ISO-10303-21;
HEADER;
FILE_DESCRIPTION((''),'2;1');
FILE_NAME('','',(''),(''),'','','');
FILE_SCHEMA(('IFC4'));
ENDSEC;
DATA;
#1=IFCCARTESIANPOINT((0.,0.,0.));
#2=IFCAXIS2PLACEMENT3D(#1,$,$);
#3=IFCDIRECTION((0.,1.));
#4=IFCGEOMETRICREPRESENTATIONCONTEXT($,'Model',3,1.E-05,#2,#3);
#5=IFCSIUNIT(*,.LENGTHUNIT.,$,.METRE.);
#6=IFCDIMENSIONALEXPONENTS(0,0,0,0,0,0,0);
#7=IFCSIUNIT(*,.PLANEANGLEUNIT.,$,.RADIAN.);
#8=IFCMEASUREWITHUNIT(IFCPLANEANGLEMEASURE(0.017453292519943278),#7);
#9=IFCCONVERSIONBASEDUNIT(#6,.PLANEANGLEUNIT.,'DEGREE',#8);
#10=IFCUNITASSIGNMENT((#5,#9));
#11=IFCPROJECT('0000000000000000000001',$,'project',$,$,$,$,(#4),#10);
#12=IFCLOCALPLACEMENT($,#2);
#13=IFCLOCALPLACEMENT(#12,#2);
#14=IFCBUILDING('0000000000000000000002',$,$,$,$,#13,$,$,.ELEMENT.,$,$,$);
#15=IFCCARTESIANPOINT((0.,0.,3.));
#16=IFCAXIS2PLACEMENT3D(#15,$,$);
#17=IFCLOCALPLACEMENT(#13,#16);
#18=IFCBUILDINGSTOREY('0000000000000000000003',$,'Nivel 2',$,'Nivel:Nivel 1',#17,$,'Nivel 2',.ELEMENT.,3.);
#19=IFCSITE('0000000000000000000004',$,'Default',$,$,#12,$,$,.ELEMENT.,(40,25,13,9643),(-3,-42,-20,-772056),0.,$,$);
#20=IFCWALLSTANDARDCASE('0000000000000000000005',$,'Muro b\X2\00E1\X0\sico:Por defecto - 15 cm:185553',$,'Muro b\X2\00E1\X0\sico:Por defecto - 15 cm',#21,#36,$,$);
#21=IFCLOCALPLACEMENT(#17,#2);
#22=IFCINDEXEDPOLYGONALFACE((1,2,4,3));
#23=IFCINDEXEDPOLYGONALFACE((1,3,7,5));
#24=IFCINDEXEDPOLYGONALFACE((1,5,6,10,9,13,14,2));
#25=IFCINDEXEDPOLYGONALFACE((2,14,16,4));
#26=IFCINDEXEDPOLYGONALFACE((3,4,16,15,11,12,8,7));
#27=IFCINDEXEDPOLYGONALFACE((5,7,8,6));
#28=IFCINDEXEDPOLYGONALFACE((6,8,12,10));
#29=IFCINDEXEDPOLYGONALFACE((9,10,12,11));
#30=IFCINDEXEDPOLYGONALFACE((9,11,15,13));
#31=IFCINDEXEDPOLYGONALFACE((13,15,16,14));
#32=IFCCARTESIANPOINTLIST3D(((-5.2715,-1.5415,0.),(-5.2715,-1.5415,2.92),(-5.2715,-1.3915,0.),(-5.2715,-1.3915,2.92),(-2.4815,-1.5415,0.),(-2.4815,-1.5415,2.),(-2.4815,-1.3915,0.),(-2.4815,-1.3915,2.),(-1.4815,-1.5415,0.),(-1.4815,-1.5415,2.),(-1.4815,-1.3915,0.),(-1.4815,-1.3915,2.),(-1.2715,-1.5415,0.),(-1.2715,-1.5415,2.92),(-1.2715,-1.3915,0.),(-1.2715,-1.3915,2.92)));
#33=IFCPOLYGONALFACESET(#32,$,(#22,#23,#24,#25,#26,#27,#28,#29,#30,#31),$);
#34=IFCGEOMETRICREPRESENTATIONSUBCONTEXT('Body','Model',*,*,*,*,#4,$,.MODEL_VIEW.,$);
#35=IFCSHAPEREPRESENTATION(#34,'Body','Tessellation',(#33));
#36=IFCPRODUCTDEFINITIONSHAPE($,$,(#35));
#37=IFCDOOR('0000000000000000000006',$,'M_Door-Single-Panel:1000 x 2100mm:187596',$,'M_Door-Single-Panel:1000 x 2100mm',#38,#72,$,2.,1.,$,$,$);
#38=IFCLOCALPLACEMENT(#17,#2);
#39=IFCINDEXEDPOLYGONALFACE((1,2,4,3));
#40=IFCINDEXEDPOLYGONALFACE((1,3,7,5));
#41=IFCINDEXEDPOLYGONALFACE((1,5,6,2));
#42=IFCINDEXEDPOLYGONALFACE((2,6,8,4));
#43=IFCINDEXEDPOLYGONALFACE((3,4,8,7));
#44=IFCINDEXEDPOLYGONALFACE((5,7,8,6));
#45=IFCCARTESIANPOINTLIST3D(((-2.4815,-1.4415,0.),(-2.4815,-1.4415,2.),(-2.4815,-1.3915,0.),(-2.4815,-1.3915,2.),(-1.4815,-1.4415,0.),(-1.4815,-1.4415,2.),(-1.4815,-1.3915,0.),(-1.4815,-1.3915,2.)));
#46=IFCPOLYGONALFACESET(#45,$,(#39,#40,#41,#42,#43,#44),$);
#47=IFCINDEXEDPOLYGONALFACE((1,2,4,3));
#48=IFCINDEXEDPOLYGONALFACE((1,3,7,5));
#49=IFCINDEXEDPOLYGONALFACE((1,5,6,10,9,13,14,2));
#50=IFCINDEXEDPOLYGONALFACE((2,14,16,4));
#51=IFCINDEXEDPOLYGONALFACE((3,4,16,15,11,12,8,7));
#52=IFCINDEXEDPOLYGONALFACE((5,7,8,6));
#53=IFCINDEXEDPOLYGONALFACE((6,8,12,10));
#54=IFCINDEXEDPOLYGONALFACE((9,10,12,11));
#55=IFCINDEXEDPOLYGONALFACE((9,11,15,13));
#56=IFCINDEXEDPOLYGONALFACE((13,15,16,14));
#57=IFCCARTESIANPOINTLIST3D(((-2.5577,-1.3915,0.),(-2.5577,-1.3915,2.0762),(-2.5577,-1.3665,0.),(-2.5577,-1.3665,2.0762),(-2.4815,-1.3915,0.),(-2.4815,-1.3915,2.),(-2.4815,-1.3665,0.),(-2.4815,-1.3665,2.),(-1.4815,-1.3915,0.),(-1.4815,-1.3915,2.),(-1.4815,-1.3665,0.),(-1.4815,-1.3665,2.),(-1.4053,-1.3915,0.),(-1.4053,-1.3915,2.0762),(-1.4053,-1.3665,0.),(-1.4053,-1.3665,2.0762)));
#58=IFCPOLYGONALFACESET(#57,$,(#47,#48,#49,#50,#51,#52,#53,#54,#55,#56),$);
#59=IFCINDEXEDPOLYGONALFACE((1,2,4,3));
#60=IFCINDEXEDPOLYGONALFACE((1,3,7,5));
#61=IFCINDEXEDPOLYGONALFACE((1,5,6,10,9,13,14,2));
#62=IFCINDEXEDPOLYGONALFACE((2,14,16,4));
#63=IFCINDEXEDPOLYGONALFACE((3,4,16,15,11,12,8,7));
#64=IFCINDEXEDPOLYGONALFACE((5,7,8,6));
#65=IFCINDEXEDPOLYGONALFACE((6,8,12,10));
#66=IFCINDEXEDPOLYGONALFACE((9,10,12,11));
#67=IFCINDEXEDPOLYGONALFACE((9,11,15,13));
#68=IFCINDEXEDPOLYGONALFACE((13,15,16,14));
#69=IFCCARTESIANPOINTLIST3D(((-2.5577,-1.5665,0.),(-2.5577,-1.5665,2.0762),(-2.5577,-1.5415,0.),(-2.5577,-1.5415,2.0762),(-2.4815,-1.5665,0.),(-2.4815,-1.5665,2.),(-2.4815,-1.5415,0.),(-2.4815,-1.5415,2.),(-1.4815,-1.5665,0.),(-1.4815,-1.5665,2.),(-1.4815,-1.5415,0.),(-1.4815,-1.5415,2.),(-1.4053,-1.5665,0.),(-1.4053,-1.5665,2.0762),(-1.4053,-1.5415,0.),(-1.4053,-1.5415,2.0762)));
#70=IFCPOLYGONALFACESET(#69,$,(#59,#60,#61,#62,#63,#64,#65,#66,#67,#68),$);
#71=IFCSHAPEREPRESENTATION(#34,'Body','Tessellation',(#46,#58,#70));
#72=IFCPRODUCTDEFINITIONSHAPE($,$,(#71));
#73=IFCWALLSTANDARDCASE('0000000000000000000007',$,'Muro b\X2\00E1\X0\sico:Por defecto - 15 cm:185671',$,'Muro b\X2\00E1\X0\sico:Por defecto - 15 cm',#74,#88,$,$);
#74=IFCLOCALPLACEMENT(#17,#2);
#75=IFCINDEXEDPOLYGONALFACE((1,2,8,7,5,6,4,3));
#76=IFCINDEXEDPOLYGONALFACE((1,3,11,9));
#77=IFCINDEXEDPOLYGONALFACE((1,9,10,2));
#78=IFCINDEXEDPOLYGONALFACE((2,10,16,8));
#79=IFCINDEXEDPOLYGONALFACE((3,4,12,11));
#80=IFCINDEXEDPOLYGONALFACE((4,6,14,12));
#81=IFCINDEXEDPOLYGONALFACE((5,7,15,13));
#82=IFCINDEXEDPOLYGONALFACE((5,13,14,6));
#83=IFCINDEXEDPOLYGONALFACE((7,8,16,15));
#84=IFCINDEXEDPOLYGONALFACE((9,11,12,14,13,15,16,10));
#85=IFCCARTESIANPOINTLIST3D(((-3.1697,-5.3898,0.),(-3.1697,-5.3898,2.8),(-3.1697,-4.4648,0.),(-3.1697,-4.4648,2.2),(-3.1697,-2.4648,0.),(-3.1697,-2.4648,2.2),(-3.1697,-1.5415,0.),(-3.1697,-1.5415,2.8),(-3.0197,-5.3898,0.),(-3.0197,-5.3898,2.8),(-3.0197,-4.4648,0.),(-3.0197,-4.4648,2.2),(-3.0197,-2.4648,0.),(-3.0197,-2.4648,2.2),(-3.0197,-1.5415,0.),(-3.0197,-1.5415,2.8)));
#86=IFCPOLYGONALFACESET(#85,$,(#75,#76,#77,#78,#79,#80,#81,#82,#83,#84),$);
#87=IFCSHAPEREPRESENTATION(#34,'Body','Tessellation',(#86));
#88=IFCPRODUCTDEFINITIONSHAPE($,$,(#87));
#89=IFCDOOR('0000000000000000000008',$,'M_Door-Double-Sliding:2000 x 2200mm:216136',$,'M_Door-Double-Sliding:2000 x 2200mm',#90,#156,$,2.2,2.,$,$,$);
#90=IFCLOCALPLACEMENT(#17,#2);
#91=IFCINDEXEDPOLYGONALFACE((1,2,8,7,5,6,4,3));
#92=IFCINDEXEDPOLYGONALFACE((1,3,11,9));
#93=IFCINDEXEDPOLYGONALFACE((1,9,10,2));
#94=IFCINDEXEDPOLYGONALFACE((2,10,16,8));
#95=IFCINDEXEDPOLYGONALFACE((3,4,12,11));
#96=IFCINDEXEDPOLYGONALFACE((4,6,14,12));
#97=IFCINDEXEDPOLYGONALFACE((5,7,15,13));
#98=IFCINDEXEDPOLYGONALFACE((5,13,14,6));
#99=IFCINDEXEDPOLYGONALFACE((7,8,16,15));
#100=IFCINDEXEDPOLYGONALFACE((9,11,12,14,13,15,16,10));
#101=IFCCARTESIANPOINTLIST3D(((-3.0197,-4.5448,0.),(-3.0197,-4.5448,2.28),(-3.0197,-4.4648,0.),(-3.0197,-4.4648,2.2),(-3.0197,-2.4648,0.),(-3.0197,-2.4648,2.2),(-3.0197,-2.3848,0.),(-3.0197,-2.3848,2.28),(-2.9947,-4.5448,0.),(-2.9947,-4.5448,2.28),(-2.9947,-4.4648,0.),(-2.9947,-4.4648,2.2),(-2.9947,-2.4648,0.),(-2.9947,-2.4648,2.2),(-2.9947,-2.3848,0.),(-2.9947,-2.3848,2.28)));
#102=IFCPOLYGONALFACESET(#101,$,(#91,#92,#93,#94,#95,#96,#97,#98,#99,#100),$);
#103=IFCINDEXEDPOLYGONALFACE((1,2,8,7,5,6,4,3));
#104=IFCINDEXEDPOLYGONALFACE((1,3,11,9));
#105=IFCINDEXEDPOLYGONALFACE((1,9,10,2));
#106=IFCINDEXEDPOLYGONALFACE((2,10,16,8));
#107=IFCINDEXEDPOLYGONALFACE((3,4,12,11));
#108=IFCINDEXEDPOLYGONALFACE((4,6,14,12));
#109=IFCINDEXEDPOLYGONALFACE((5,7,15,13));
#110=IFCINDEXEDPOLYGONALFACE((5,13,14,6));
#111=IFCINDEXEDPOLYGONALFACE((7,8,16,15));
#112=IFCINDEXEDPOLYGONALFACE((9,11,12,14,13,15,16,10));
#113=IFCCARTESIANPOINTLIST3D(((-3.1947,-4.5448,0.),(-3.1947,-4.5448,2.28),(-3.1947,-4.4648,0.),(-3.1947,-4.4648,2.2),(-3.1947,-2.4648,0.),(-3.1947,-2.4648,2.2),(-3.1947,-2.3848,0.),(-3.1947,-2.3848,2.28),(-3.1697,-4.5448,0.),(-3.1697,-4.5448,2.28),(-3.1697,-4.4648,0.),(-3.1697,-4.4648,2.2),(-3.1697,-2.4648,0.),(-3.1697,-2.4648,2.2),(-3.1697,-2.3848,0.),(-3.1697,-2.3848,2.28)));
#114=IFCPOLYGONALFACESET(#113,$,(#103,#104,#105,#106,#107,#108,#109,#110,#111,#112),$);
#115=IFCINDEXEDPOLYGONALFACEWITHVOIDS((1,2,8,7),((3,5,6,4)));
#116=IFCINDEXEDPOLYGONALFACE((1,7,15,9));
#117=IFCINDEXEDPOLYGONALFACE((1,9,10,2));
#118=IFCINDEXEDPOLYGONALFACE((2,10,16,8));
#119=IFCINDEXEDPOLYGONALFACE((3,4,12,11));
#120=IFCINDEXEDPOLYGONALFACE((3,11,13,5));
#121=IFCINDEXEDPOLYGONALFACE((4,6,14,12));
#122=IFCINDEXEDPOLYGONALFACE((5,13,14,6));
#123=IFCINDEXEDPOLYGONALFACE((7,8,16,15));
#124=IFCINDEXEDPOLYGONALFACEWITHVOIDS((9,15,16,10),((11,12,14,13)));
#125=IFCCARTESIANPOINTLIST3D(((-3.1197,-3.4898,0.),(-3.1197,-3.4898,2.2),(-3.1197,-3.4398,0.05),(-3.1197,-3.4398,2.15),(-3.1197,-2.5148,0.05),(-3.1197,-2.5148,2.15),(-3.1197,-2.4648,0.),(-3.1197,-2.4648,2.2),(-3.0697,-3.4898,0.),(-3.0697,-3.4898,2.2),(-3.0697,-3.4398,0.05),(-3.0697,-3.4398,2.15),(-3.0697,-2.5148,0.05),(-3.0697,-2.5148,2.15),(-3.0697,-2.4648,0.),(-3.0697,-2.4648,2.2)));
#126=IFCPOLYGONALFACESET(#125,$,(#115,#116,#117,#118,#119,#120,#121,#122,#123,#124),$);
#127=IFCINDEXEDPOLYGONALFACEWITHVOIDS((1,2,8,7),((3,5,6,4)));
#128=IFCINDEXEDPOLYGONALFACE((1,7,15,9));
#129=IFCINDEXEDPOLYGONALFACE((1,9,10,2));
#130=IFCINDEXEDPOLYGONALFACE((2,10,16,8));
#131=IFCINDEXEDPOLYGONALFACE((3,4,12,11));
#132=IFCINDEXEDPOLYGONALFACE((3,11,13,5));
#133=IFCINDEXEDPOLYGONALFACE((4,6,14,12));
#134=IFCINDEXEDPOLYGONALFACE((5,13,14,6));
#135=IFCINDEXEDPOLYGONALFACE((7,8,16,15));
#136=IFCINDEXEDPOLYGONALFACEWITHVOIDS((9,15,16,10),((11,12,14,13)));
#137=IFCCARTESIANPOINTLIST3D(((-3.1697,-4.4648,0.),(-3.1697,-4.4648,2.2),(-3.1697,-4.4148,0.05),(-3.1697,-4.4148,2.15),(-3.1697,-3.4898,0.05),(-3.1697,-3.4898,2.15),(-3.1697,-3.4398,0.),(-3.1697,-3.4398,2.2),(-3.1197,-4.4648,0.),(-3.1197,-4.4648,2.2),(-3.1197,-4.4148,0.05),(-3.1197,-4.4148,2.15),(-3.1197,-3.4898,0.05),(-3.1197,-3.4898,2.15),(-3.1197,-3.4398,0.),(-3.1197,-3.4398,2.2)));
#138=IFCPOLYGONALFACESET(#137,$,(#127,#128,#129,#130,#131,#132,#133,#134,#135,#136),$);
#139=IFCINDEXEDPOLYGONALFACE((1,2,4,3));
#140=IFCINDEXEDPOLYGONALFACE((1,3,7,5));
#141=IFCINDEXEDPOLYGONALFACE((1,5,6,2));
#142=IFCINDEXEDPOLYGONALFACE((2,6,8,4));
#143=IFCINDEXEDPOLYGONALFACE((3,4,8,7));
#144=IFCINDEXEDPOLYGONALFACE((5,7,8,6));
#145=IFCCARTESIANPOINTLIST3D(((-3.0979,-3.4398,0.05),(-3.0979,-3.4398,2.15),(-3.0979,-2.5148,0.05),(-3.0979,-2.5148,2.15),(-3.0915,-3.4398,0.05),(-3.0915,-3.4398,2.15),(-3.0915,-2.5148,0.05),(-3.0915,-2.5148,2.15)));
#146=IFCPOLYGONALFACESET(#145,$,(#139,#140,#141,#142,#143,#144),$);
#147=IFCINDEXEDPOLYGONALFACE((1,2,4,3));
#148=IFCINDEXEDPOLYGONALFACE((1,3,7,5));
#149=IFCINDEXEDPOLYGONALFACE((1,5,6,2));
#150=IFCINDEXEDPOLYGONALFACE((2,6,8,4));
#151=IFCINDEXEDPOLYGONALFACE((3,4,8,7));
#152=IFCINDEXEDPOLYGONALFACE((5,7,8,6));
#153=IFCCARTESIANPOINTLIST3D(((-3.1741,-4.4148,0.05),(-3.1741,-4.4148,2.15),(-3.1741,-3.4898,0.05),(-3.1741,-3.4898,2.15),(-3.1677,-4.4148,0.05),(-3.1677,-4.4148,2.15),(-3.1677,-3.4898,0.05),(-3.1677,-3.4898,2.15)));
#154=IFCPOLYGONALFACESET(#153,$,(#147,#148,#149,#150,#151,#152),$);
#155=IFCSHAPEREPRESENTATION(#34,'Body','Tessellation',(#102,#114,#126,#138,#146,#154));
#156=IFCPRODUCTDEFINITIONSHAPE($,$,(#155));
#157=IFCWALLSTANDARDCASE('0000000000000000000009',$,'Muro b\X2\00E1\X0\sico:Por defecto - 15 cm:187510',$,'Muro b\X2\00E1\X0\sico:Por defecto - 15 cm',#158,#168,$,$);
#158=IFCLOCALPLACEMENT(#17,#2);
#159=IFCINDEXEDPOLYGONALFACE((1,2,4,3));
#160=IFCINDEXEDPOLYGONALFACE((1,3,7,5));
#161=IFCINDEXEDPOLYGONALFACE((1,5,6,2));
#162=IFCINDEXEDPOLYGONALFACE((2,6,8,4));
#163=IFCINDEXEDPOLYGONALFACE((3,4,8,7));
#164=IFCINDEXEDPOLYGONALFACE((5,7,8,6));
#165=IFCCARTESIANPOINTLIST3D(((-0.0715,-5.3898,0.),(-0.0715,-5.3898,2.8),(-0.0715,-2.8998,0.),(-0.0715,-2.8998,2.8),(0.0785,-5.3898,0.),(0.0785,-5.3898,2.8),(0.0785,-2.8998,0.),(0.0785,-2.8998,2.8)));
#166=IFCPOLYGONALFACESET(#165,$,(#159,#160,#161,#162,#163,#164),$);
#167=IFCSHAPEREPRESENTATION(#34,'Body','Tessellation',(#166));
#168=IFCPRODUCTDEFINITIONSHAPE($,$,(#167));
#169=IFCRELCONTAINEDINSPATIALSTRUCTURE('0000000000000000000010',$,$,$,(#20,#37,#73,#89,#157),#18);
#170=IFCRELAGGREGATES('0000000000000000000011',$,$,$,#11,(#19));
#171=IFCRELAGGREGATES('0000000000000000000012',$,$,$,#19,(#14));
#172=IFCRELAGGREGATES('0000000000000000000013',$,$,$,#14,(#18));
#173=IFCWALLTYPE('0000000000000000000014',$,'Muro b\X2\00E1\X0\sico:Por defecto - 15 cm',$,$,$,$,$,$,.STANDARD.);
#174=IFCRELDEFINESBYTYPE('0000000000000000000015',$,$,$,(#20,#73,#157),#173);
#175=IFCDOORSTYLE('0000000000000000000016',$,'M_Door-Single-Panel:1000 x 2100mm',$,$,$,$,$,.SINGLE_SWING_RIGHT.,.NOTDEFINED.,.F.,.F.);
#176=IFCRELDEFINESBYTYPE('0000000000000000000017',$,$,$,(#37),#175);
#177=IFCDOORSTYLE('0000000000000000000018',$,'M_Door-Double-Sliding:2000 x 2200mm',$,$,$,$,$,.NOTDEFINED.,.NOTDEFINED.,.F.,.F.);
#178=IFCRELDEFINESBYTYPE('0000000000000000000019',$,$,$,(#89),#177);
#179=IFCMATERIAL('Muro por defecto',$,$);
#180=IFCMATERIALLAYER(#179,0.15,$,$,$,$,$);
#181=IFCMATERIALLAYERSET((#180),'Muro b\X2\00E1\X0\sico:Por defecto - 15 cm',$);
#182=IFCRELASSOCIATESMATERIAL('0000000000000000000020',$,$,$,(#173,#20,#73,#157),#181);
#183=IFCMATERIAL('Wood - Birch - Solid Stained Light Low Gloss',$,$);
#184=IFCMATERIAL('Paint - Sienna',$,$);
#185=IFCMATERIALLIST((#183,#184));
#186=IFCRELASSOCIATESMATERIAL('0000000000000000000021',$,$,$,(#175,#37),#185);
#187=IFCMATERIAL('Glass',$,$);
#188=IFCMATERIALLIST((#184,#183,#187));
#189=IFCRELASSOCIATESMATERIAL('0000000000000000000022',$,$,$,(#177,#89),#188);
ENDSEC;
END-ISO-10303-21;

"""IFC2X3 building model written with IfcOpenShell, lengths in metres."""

from ifc_helpers import new_model, entity, si_unit, converted_unit, direction, frame, frame_2d, origin, origin_2d_with_axis, place, context, subcontext, project, spatial, polyline, rectangle, outline, extrude, clip, bounded_halfspace, source, transform, mapped, material, material_list, layer, layer_set, layer_usage, type_object, type_shapes, element, fill, save


model = new_model("IFC2X3")

# Units and contexts
model_context = context("Model", 3, precision=1e-05, world=origin(), true_north=direction((0.0, 1.0)))
body_context = subcontext(model_context, "Body", "Model", "MODEL_VIEW")
ifc_project = project(units=[si_unit("LENGTHUNIT", "METRE"), converted_unit("PLANEANGLEUNIT", "DEGREE", entity("IfcPlaneAngleMeasure", 0.017453292519943278), si_unit("PLANEANGLEUNIT", "RADIAN"), dimensions=[0, 0, 0, 0, 0, 0, 0])], contexts=[model_context])

# Site, building, storey
site_placement = place(None, origin())
site = spatial("IfcSite", under=ifc_project, at=site_placement, Name="Default", CompositionType="ELEMENT", RefLatitude=(40, 25, 13, 9643), RefLongitude=(-3, -42, -20, -772056), RefElevation=0.0)
building_placement = place(site_placement, origin())
building = spatial("IfcBuilding", under=site, at=building_placement, CompositionType="ELEMENT")
storey_placement = place(building_placement, frame((0.0, 0.0, 3.0)))
storey = spatial("IfcBuildingStorey", under=building, at=storey_placement, Name="Nivel 2", ObjectType="Nivel:Nivel 1", LongName="Nivel 2", CompositionType="ELEMENT", Elevation=3.0)

# Shared definitions
ifc_material_1 = material(Name="Muro por defecto")
ifc_layer_1 = layer(ifc_material_1, 0.15)
ifc_layer_set_1 = layer_set([ifc_layer_1], Name="Muro básico:Por defecto - 15 cm")
wall_type = type_object("IfcWallType", Name="Muro básico:Por defecto - 15 cm", PredefinedType="STANDARD", material=ifc_layer_set_1)

# Walls, openings, doors
ifc_material_2 = material(Name="Wood - Birch - Solid Stained Light Low Gloss")
ifc_material_3 = material(Name="Paint - Sienna")
ifc_material_list_1 = material_list([ifc_material_2, ifc_material_3])
ifc_layer_usage_1 = layer_usage(ifc_layer_set_1, "AXIS2", "NEGATIVE", 0.075)
wall_1_placement = place(storey_placement, frame((-1.2715, -1.4665, 0.0), z_axis=(0.0, 0.0, 1.0), x_axis=(-1.0, 0.0, 0.0)))
wall_1 = element("IfcWallStandardCase", 1, at=wall_1_placement, inside=storey, type_object=wall_type, material=ifc_layer_usage_1, Name="Muro básico:Por defecto - 15 cm:185553", ObjectType="Muro básico:Por defecto - 15 cm", context=body_context, shape_type="SweptSolid", body=[
    extrude(rectangle(XDim=4.0, YDim=0.15, at=frame_2d((2.0, 0.0), x_axis=(-1.0, 0.0))), origin(), (0.0, 0.0, 1.0), 2.92),
])
opening_1_placement = place(wall_1_placement, frame((1.21, 0.075, 0.0)))
opening_1 = element("IfcOpeningElement", 2, at=opening_1_placement, cuts=wall_1, ObjectType="Opening", context=body_context, shape_type="SweptSolid", body=[
    extrude(rectangle(XDim=1.0, YDim=2.0, at=frame_2d((1.0, 0.5), x_axis=(0.0, 1.0))), frame((0.0, 0.0, 0.0), z_axis=(0.0, -1.0, 0.0), x_axis=(0.0, 0.0, 1.0)), (0.0, 0.0, 1.0), 0.15),
])
door_style_1 = type_object("IfcDoorStyle", Name="M_Door-Single-Panel:1000 x 2100mm", ConstructionType="NOTDEFINED", OperationType="SINGLE_SWING_RIGHT", ParameterTakesPrecedence=False, Sizeable=False, material=ifc_material_list_1)
shared_shape_1 = source(origin(), body_context, "Body", "SweptSolid", [
    extrude(rectangle(XDim=0.05, YDim=1.0, at=origin_2d_with_axis()), frame((0.5, 0.125, 0.0), z_axis=(0.0, 0.0, 1.0), x_axis=(0.0, 1.0, 0.0)), (0.0, 0.0, 1.0), 2.0),
    extrude(outline(polyline([(-0.5762, -1.0571), (0.5762, -1.0571), (0.5762, 1.0191), (0.5, 1.0191), (0.5, -0.981), (-0.5, -0.981), (-0.5, 1.0191), (-0.5762, 1.0191), (-0.5762, -1.0571)])), frame((0.5, 0.15, 1.0191), z_axis=(0.0, 1.0, 0.0), x_axis=(1.0, 0.0, 0.0)), (0.0, 0.0, 1.0), 0.025),
    extrude(outline(polyline([(-1.0571, -0.5762), (1.019, -0.5762), (1.019, -0.5), (-0.9809, -0.5), (-0.9809, 0.5), (1.019, 0.5), (1.019, 0.5762), (-1.0571, 0.5762), (-1.0571, -0.5762)])), frame((0.5, -0.025, 1.019), z_axis=(0.0, 1.0, 0.0), x_axis=(0.0, 0.0, -1.0)), (0.0, 0.0, 1.0), 0.025),
])
type_shapes(door_style_1, [shared_shape_1])
door_1_placement = place(opening_1_placement, frame((0.0, 0.0, 0.0), z_axis=(0.0, 0.0, 1.0), x_axis=(-1.0, 0.0, 0.0)))
door_1 = element("IfcDoor", 3, at=door_1_placement, inside=storey, type_object=door_style_1, material=ifc_material_list_1, Name="M_Door-Single-Panel:1000 x 2100mm:187596", ObjectType="M_Door-Single-Panel:1000 x 2100mm", OverallHeight=2.0, OverallWidth=1.0, context=body_context, shape_type="MappedRepresentation", body=[
    mapped(shared_shape_1, transform((0.0, 0.0, 0.0), scale=1.0)),
])
fill(opening_1, door_1)
ifc_layer_usage_2 = layer_usage(ifc_layer_set_1, "AXIS2", "POSITIVE", -0.075)
wall_2_placement = place(storey_placement, frame((-3.0947, -1.5415, 0.0), z_axis=(0.0, 0.0, 1.0), x_axis=(0.0, -1.0, 0.0)))
wall_2 = element("IfcWallStandardCase", 4, at=wall_2_placement, inside=storey, type_object=wall_type, material=ifc_layer_usage_2, Name="Muro básico:Por defecto - 15 cm:185671", ObjectType="Muro básico:Por defecto - 15 cm", context=body_context, shape_type="Clipping", body=[
    clip(extrude(rectangle(XDim=3.8482, YDim=0.15, at=frame_2d((1.9241, 0.0), x_axis=(1.0, 0.0))), origin(), (0.0, 0.0, 1.0), 2.8), bounded_halfspace(frame((0.0, -0.075, 2.8), z_axis=(0.0, 0.0, -1.0), x_axis=(0.0, 1.0, 0.0)), True, frame((0.0, -0.075, 2.8)), polyline([(0.0, 0.0), (3.8482, 0.0), (3.8482, 0.15), (0.0, 0.15), (0.0, 0.0)]))),
])
opening_2_placement = place(wall_2_placement, frame((2.9232, 0.075, 0.0)))
opening_2 = element("IfcOpeningElement", 5, at=opening_2_placement, cuts=wall_2, ObjectType="Opening", context=body_context, shape_type="SweptSolid", body=[
    extrude(rectangle(XDim=2.2, YDim=2.0, at=frame_2d((1.1, 1.0), x_axis=(-1.0, 0.0))), frame((0.0, 0.0, 0.0), z_axis=(0.0, -1.0, 0.0), x_axis=(0.0, 0.0, 1.0)), (0.0, 0.0, 1.0), 0.15),
])
ifc_material_4 = material(Name="Glass")
ifc_material_list_2 = material_list([ifc_material_3, ifc_material_2, ifc_material_4])
door_style_2 = type_object("IfcDoorStyle", Name="M_Door-Double-Sliding:2000 x 2200mm", ConstructionType="NOTDEFINED", OperationType="NOTDEFINED", ParameterTakesPrecedence=False, Sizeable=False, material=ifc_material_list_2)
shared_shape_2 = source(origin(), body_context, "Body", "SweptSolid", [
    extrude(outline(polyline([(-1.12, -1.08), (1.16, -1.08), (1.16, 1.08), (-1.12, 1.08), (-1.12, 1.0), (1.08, 1.0), (1.08, -1.0), (-1.12, -1.0), (-1.12, -1.08)])), frame((1.0, -0.025, 1.12), z_axis=(0.0, 1.0, 0.0), x_axis=(0.0, 0.0, 1.0)), (0.0, 0.0, 1.0), 0.025),
    extrude(outline(polyline([(-1.08, -1.12), (-1.0, -1.12), (-1.0, 1.08), (1.0, 1.08), (1.0, -1.12), (1.08, -1.12), (1.08, 1.16), (-1.08, 1.16), (-1.08, -1.12)])), frame((1.0, 0.15, 1.12), z_axis=(0.0, 1.0, 0.0), x_axis=(-1.0, 0.0, 0.0)), (0.0, 0.0, 1.0), 0.025),
    extrude(outline(polyline([(-0.5125, -1.1), (0.5125, -1.1), (0.5125, 1.1), (-0.5125, 1.1), (-0.5125, -1.1)]), holes=[polyline([(-0.4625, -1.05), (-0.4625, 1.05), (0.4625, 1.05), (0.4625, -1.05), (-0.4625, -1.05)])]), frame((1.4875, 0.05, 1.1), z_axis=(0.0, 1.0, 0.0), x_axis=(1.0, 0.0, 0.0)), (0.0, 0.0, 1.0), 0.05),
    extrude(outline(polyline([(-1.1, -0.5125), (1.1, -0.5125), (1.1, 0.5125), (-1.1, 0.5125), (-1.1, -0.5125)]), holes=[polyline([(-1.05, -0.4625), (-1.05, 0.4625), (1.05, 0.4625), (1.05, -0.4625), (-1.05, -0.4625)])]), frame((0.5125, 0.1, 1.1), z_axis=(0.0, 1.0, 0.0), x_axis=(0.0, 0.0, -1.0)), (0.0, 0.0, 1.0), 0.05),
    extrude(rectangle(XDim=0.0063, YDim=0.925, at=origin_2d_with_axis()), frame((1.4875, 0.075, 0.05), z_axis=(0.0, 0.0, 1.0), x_axis=(0.0, -1.0, 0.0)), (0.0, 0.0, 1.0), 2.1),
    extrude(rectangle(XDim=0.0064, YDim=0.925, at=origin_2d_with_axis()), frame((0.5125, 0.1512, 0.05), z_axis=(0.0, 0.0, 1.0), x_axis=(0.0, 1.0, 0.0)), (0.0, 0.0, 1.0), 2.1),
])
type_shapes(door_style_2, [shared_shape_2])
door_2_placement = place(opening_2_placement, frame((0.0, 0.0, 0.0), z_axis=(0.0, 0.0, 1.0), x_axis=(-1.0, 0.0, 0.0)))
door_2 = element("IfcDoor", 6, at=door_2_placement, inside=storey, type_object=door_style_2, material=ifc_material_list_2, Name="M_Door-Double-Sliding:2000 x 2200mm:216136", ObjectType="M_Door-Double-Sliding:2000 x 2200mm", OverallHeight=2.2, OverallWidth=2.0, context=body_context, shape_type="MappedRepresentation", body=[
    mapped(shared_shape_2, transform((0.0, 0.0, 0.0), scale=1.0)),
])
fill(opening_2, door_2)

# Wall
ifc_layer_usage_3 = layer_usage(ifc_layer_set_1, "AXIS2", "NEGATIVE", 0.075)
wall_3_placement = place(storey_placement, frame((0.0035, -5.3898, 0.0), z_axis=(0.0, 0.0, 1.0), x_axis=(0.0, 1.0, 0.0)))
element("IfcWallStandardCase", 7, at=wall_3_placement, inside=storey, type_object=wall_type, material=ifc_layer_usage_3, Name="Muro básico:Por defecto - 15 cm:187510", ObjectType="Muro básico:Por defecto - 15 cm", context=body_context, shape_type="Clipping", body=[
    clip(extrude(rectangle(XDim=2.49, YDim=0.15, at=frame_2d((1.245, 0.0), x_axis=(-1.0, 0.0))), origin(), (0.0, 0.0, 1.0), 2.8), bounded_halfspace(frame((0.0, -0.075, 2.8), z_axis=(0.0, 0.0, -1.0), x_axis=(0.0, -1.0, 0.0)), True, frame((0.0, -0.075, 2.8)), polyline([(0.0, 0.0), (2.49, 0.0), (2.49, 0.15), (0.0, 0.15), (0.0, 0.0)]))),
])

save(model, "model.ifc")
